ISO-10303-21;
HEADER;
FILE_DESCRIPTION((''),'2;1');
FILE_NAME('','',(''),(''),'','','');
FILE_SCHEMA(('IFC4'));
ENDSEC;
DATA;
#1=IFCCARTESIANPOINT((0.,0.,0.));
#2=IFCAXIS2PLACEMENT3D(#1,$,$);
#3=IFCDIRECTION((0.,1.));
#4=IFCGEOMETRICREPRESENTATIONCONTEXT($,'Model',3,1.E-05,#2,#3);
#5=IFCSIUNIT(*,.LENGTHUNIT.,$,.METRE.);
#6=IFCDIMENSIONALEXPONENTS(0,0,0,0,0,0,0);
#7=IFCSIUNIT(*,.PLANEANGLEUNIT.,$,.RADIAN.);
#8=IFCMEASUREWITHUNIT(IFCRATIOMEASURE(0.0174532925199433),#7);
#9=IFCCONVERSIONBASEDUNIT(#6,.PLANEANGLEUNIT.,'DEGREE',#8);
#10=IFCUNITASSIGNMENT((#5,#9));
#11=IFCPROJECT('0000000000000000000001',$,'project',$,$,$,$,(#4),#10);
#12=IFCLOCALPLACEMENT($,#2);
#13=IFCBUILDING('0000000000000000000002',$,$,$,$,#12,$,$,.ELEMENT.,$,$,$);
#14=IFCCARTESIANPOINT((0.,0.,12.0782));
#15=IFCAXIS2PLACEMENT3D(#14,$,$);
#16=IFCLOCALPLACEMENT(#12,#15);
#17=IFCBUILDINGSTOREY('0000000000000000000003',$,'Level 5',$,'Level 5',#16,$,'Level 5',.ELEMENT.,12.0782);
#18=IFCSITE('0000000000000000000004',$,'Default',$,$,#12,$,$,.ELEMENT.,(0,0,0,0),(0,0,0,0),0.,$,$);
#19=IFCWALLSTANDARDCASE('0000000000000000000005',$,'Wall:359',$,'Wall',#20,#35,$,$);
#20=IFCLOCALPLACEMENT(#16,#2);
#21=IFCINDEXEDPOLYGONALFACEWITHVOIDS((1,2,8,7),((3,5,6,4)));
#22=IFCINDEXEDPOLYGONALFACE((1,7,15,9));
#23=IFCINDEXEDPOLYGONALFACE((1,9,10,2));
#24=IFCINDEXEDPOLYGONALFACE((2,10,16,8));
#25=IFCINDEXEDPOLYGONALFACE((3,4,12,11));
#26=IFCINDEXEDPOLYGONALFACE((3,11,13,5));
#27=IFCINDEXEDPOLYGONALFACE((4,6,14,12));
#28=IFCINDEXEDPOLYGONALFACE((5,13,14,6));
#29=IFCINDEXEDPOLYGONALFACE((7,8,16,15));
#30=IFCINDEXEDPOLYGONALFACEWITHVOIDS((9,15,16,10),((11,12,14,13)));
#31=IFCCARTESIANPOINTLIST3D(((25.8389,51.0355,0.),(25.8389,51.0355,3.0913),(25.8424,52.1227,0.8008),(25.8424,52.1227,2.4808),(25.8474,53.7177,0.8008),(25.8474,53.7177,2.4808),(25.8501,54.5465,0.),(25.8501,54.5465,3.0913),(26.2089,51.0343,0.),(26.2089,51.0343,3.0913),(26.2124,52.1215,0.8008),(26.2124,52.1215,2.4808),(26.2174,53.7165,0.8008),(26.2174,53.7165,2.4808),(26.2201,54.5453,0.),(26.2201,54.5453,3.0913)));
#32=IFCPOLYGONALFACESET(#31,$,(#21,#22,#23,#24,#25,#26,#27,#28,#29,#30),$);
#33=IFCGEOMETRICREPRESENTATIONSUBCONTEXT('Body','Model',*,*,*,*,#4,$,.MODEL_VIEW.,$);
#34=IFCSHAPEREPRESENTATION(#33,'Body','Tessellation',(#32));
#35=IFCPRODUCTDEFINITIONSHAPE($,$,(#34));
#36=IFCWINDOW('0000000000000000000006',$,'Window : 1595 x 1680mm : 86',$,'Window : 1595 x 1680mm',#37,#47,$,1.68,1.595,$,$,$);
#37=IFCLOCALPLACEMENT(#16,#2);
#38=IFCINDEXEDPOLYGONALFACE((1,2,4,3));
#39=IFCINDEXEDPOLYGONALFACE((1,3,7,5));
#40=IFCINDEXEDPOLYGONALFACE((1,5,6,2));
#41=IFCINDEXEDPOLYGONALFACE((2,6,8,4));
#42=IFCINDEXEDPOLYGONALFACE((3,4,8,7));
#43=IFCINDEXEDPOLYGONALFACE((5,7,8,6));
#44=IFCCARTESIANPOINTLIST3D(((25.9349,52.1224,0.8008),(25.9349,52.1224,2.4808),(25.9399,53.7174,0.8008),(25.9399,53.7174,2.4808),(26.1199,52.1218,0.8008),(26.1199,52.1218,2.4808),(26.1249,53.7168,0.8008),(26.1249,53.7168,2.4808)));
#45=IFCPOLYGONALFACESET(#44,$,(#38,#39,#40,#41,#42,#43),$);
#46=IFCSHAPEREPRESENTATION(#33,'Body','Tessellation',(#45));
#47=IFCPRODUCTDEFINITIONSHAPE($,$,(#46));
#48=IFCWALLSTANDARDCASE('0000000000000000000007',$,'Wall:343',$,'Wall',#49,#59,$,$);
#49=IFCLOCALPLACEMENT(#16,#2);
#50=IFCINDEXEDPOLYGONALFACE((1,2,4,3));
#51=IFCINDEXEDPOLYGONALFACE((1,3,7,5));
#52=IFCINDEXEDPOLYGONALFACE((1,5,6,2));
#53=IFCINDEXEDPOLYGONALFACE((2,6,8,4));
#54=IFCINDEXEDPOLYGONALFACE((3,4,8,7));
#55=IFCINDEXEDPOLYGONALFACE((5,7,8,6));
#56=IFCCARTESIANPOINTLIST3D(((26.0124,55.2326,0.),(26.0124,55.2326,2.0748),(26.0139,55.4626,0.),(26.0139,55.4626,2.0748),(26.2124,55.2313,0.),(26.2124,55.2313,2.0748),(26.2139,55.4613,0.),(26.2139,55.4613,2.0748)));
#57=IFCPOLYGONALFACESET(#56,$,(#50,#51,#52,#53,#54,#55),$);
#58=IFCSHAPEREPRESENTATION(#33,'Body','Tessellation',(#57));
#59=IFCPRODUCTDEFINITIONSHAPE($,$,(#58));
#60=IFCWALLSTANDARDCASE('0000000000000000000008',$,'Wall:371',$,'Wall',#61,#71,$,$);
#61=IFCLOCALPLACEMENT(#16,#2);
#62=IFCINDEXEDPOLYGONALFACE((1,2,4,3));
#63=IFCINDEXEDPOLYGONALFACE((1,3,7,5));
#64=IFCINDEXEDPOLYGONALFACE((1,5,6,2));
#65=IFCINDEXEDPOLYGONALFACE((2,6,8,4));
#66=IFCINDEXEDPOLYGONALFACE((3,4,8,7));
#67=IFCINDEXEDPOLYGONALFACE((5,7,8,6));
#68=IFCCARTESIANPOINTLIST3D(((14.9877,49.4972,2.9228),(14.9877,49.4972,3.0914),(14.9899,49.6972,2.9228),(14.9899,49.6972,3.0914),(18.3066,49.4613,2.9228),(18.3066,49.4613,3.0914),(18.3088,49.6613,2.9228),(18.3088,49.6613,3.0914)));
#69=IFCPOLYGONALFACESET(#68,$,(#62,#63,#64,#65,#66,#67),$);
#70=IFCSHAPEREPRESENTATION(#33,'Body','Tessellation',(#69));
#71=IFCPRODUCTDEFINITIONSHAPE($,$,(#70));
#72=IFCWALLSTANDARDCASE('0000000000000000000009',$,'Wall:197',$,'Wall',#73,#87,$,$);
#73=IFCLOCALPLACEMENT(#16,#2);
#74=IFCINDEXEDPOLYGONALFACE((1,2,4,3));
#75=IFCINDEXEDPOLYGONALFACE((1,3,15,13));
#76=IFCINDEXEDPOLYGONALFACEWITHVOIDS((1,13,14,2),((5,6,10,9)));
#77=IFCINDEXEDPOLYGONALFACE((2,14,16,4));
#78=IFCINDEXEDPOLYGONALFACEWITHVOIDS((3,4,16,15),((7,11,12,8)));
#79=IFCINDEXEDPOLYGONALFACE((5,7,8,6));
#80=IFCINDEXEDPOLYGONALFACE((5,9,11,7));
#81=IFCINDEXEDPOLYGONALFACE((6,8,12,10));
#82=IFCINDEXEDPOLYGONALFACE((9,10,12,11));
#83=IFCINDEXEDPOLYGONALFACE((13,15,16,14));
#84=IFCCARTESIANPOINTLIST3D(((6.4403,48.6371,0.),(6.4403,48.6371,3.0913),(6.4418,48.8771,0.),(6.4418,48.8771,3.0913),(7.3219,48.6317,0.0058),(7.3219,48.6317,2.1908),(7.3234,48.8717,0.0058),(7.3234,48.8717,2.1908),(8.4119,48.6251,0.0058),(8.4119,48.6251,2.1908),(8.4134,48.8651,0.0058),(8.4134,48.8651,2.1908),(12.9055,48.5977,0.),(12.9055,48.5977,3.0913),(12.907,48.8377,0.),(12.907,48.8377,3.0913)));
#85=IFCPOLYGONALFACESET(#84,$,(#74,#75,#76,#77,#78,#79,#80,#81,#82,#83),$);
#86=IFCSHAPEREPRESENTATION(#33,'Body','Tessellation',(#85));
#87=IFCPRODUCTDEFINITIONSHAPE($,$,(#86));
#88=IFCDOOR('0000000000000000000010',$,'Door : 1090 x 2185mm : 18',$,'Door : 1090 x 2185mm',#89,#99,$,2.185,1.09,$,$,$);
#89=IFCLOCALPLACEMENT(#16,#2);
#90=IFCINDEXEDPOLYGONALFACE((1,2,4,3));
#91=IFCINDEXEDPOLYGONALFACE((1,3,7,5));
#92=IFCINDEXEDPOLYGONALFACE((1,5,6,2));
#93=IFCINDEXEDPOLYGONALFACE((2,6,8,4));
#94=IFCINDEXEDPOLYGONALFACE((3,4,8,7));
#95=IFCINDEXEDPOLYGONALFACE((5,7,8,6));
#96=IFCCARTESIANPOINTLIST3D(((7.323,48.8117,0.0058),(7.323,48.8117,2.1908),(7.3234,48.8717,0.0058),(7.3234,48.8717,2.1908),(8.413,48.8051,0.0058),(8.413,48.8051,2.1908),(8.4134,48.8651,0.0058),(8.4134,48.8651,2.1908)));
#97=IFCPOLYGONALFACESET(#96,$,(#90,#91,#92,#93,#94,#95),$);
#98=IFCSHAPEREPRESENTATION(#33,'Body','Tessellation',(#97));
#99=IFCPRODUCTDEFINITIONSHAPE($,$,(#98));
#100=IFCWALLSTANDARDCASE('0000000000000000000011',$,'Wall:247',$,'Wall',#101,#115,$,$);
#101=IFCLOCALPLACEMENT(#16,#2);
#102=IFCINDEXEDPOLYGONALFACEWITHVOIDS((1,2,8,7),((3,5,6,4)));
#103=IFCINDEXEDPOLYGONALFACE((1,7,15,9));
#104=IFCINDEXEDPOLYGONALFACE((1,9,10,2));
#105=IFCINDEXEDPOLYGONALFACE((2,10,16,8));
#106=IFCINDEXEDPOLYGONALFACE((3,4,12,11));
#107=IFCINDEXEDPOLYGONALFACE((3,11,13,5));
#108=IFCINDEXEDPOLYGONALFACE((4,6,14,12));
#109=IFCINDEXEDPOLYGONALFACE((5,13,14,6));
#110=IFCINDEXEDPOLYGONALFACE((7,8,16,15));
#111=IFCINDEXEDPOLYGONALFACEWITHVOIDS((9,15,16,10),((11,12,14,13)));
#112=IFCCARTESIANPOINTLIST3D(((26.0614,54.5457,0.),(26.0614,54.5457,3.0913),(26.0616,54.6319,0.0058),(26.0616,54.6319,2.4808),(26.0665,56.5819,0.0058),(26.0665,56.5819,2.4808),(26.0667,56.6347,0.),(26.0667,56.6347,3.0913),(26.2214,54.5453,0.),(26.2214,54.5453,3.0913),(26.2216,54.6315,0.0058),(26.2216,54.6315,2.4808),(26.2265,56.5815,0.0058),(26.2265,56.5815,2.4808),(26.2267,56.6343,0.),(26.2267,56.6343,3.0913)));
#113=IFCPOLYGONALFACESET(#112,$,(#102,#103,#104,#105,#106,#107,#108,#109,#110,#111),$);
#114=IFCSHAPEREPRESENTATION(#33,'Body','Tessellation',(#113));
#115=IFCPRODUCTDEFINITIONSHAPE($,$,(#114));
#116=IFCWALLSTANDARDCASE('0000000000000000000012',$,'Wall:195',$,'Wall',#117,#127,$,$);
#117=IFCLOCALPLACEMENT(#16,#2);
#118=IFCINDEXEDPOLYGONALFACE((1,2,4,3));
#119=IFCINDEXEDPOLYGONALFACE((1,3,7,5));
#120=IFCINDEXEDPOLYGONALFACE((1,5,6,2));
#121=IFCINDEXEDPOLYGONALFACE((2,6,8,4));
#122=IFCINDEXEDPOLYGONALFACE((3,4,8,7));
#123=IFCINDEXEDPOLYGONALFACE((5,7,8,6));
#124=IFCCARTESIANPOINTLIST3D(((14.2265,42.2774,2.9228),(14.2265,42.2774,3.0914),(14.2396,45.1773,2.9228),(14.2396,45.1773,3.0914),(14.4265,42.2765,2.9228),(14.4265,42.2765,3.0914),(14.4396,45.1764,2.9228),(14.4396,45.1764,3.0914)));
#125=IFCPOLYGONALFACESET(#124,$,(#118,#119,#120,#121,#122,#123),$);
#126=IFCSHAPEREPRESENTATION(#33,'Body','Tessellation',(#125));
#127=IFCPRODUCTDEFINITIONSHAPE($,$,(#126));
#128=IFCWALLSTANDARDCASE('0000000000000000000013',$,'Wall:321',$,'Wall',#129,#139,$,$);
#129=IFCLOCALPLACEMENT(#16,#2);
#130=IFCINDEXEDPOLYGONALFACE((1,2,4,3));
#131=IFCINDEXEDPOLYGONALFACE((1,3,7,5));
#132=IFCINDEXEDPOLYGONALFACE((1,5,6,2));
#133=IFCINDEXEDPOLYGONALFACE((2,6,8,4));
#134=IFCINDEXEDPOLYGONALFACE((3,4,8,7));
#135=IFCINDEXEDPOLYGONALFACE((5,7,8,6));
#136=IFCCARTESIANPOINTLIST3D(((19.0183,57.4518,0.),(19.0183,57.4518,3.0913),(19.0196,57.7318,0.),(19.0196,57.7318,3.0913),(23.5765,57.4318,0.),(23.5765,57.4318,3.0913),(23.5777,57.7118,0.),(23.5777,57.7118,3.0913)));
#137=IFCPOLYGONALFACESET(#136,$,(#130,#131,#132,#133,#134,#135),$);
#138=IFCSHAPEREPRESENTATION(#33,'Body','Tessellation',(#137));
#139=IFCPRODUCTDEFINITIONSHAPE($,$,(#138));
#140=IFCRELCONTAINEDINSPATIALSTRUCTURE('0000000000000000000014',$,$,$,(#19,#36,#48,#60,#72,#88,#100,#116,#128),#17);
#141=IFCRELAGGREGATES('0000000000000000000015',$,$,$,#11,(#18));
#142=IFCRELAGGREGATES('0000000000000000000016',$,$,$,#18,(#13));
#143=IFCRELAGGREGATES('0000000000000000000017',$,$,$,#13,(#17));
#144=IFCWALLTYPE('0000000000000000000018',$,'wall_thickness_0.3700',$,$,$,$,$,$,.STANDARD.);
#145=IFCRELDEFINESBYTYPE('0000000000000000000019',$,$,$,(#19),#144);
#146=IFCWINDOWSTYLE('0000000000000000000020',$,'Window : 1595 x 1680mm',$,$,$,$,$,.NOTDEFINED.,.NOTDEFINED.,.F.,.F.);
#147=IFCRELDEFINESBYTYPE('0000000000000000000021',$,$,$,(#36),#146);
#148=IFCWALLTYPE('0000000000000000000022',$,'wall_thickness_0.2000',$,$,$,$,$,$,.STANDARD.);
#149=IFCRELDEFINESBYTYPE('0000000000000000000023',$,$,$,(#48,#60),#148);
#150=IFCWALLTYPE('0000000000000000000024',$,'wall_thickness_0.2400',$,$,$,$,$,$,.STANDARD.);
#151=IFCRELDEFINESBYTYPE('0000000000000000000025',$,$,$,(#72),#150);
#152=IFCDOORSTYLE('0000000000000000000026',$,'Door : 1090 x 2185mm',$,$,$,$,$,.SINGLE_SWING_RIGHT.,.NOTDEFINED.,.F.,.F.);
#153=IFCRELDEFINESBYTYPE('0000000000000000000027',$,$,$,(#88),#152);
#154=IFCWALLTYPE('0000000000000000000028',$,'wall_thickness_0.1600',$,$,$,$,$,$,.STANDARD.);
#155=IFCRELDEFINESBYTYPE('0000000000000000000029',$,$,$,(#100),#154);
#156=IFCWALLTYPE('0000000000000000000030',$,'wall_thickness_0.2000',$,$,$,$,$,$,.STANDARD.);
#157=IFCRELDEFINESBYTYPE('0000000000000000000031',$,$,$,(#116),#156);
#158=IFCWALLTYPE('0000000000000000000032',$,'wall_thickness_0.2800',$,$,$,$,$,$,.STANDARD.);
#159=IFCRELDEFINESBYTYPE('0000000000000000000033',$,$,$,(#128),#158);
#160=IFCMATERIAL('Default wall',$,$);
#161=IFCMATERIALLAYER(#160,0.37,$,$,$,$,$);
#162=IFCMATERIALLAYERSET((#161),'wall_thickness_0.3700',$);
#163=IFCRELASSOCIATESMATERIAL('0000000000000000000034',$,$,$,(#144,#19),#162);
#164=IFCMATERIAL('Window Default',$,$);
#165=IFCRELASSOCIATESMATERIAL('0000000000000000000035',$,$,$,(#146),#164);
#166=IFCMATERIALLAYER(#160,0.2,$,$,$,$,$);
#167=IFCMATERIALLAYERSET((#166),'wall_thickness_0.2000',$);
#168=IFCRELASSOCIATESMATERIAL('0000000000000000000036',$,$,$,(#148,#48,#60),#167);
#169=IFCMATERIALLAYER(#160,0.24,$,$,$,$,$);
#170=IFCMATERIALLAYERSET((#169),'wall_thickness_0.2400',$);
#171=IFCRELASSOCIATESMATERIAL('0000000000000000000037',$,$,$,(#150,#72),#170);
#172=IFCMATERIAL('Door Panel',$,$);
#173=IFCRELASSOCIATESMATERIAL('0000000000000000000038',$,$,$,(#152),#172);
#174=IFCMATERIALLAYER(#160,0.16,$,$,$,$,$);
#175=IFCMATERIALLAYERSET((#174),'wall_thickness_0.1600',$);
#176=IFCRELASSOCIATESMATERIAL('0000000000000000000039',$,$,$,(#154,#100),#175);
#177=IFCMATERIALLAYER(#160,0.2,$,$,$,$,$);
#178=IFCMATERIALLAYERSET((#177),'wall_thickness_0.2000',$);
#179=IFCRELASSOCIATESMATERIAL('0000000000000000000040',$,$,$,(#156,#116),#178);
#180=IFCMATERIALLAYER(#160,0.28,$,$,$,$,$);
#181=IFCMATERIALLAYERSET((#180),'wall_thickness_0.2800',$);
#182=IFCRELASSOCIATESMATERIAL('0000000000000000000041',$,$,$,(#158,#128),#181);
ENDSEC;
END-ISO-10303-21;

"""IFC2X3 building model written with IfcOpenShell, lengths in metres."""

from ifc_helpers import new_model, entity, si_unit, converted_unit, direction, frame, frame_2d, origin, origin_2d_with_axis, place, context, subcontext, project, spatial, polyline, rectangle, outline, extrude, clip, halfspace, source, transform, mapped, material, layer, layer_set, layer_usage, type_object, type_shapes, element, fill, save


model = new_model("IFC2X3")

# Units and contexts
model_context = context("Model", 3, precision=1e-05, world=origin(), true_north=direction((0.0, 1.0)))
body_context = subcontext(model_context, "Body", "Model", "MODEL_VIEW")
ifc_project = project(units=[si_unit("LENGTHUNIT", "METRE"), converted_unit("PLANEANGLEUNIT", "DEGREE", entity("IfcRatioMeasure", 0.0174532925199433), si_unit("PLANEANGLEUNIT", "RADIAN"), dimensions=[0, 0, 0, 0, 0, 0, 0])], contexts=[model_context])

# Site, building, storey
placement_1 = place(None, origin())
site = spatial("IfcSite", under=ifc_project, at=placement_1, Name="Default", CompositionType="ELEMENT", RefLatitude=(0, 0, 0, 0), RefLongitude=(0, 0, 0, 0), RefElevation=0.0)
building = spatial("IfcBuilding", under=site, at=placement_1, CompositionType="ELEMENT")
storey_placement = place(placement_1, frame((0.0, 0.0, 12.0782)))
storey = spatial("IfcBuildingStorey", under=building, at=storey_placement, Name="Level 5", ObjectType="Level 5", LongName="Level 5", CompositionType="ELEMENT", Elevation=12.0782)

# Shared definitions
ifc_material_1 = material(Name="Default wall")

# Shared definitions
ifc_material_2 = material(Name="Window Default")

# Shared definitions
ifc_material_3 = material(Name="Door Panel")

# Shared definitions
ifc_layer_1 = layer(ifc_material_1, 0.37)
ifc_layer_set_1 = layer_set([ifc_layer_1], Name="wall_thickness_0.3700")
ifc_layer_usage_1 = layer_usage(ifc_layer_set_1, "AXIS2", "POSITIVE", -0.185)
wall_type_1 = type_object("IfcWallType", Name="wall_thickness_0.3700", PredefinedType="STANDARD", material=ifc_layer_set_1)

# Wall, opening, window
wall_1_placement = place(storey_placement, frame((26.0351, 54.5459, 0.0), z_axis=(0.0, 0.0, 1.0), x_axis=(-0.00319, -0.999995, 0.0)))
wall_1 = element("IfcWallStandardCase", 1, at=wall_1_placement, inside=storey, type_object=wall_type_1, material=ifc_layer_usage_1, Name="Wall:359", ObjectType="Wall", context=body_context, shape_type="SweptSolid", body=[
    extrude(outline(polyline([(3.5111, -0.185), (3.5111, 0.185), (0.0, 0.185), (0.0, -0.185), (3.5111, -0.185)])), origin(), (0.0, 0.0, 1.0), 3.0913),
])
opening_1_placement = place(wall_1_placement, frame((0.8288, -0.185, 0.8008)))
opening_1 = element("IfcOpeningElement", 2, at=opening_1_placement, cuts=wall_1, ObjectType="Opening", context=body_context, shape_type="SweptSolid", body=[
    extrude(rectangle(XDim=1.595, YDim=1.68, at=frame_2d((0.84, 0.7975), x_axis=(0.0, 1.0))), frame((0.0, 0.0, 0.0), z_axis=(0.0, 1.0, 0.0), x_axis=(0.0, 0.0, 1.0)), (0.0, 0.0, 1.0), 0.37),
])
window_style_1 = type_object("IfcWindowStyle", Name="Window : 1595 x 1680mm", ConstructionType="NOTDEFINED", OperationType="NOTDEFINED", ParameterTakesPrecedence=False, Sizeable=False, material=ifc_material_2)
shared_shape_1 = source(origin(), body_context, "Body", "SweptSolid", [
    extrude(rectangle(XDim=0.185, YDim=1.595, at=origin_2d_with_axis()), frame((0.7975, 0.185, 0.0), z_axis=(0.0, 0.0, 1.0), x_axis=(0.0, 1.0, 0.0)), (0.0, 0.0, 1.0), 1.68),
])
type_shapes(window_style_1, [shared_shape_1])
window_1_placement = place(opening_1_placement, origin())
window_1 = element("IfcWindow", 3, at=window_1_placement, inside=storey, type_object=window_style_1, Name="Window : 1595 x 1680mm : 86", ObjectType="Window : 1595 x 1680mm", OverallHeight=1.68, OverallWidth=1.595, context=body_context, shape_type="MappedRepresentation", body=[
    mapped(shared_shape_1, transform((0.0, 0.0, 0.0), scale=1.0)),
])
fill(opening_1, window_1)

# Walls
ifc_layer_2 = layer(ifc_material_1, 0.2)
ifc_layer_set_2 = layer_set([ifc_layer_2], Name="wall_thickness_0.2000")
ifc_layer_usage_2 = layer_usage(ifc_layer_set_2, "AXIS2", "POSITIVE", -0.1)
wall_type_2 = type_object("IfcWallType", Name="wall_thickness_0.2000", PredefinedType="STANDARD", material=ifc_layer_set_2)
wall_2_placement = place(storey_placement, frame((26.1139, 55.4619, 0.0), z_axis=(0.0, 0.0, 1.0), x_axis=(-0.006286, -0.99998, 0.0)))
element("IfcWallStandardCase", 4, at=wall_2_placement, inside=storey, type_object=wall_type_2, material=ifc_layer_usage_2, Name="Wall:343", ObjectType="Wall", context=body_context, shape_type="SweptSolid", body=[
    extrude(outline(polyline([(0.23, -0.1), (0.23, 0.1), (0.0, 0.1), (0.0, -0.1), (0.23, -0.1)])), origin(), (0.0, 0.0, 1.0), 2.0748),
])
placement_2 = place(placement_1, frame((0.0, 0.0, 15.001)))
wall_3_placement = place(placement_2, frame((14.9888, 49.5972, 0.0), z_axis=(0.0, 0.0, 1.0), x_axis=(0.999942, -0.010814, 0.0)))
element("IfcWallStandardCase", 5, at=wall_3_placement, inside=storey, type_object=wall_type_2, material=ifc_layer_usage_2, Name="Wall:371", ObjectType="Wall", context=body_context, shape_type="SweptSolid", body=[
    extrude(outline(polyline([(3.3191, -0.1), (3.3191, 0.1), (0.0, 0.1), (0.0, -0.1), (3.3191, -0.1)])), origin(), (0.0, 0.0, 1.0), 0.1686),
])

# Wall, opening, door
ifc_layer_3 = layer(ifc_material_1, 0.24)
ifc_layer_set_3 = layer_set([ifc_layer_3], Name="wall_thickness_0.2400")
ifc_layer_usage_3 = layer_usage(ifc_layer_set_3, "AXIS2", "POSITIVE", -0.12)
wall_type_3 = type_object("IfcWallType", Name="wall_thickness_0.2400", PredefinedType="STANDARD", material=ifc_layer_set_3)
wall_4_placement = place(storey_placement, frame((6.4411, 48.7571, 0.0), z_axis=(0.0, 0.0, 1.0), x_axis=(0.999981, -0.006101, 0.0)))
wall_4 = element("IfcWallStandardCase", 6, at=wall_4_placement, inside=storey, type_object=wall_type_3, material=ifc_layer_usage_3, Name="Wall:197", ObjectType="Wall", context=body_context, shape_type="Clipping", body=[
    clip(extrude(outline(polyline([(6.4653, -0.12), (6.4653, 0.12), (0.0, 0.12), (0.0, -0.12), (6.4653, -0.12)])), origin(), (0.0, 0.0, 1.0), 3.0913), halfspace(frame((7.4672, 28.5225, 5.8218), z_axis=(0.390505, 0.000479, 0.920601), x_axis=(-0.920599, -0.001625, 0.390505)), False)),
])
opening_2_placement = place(wall_4_placement, frame((0.8816, -0.12, 0.0058)))
opening_2 = element("IfcOpeningElement", 7, at=opening_2_placement, cuts=wall_4, ObjectType="Opening", context=body_context, shape_type="SweptSolid", body=[
    extrude(rectangle(XDim=1.09, YDim=2.185, at=frame_2d((1.0925, 0.545), x_axis=(0.0, 1.0))), frame((0.0, 0.0, 0.0), z_axis=(0.0, 1.0, 0.0), x_axis=(0.0, 0.0, 1.0)), (0.0, 0.0, 1.0), 0.24),
])
door_style_1 = type_object("IfcDoorStyle", Name="Door : 1090 x 2185mm", ConstructionType="NOTDEFINED", OperationType="SINGLE_SWING_RIGHT", ParameterTakesPrecedence=False, Sizeable=False, material=ifc_material_3)
shared_shape_2 = source(origin(), body_context, "Body", "SweptSolid", [
    extrude(rectangle(XDim=0.06, YDim=1.09, at=origin_2d_with_axis()), frame((0.545, 0.21, 0.0), z_axis=(0.0, 0.0, 1.0), x_axis=(0.0, 1.0, 0.0)), (0.0, 0.0, 1.0), 2.185),
])
type_shapes(door_style_1, [shared_shape_2])
door_1_placement = place(opening_2_placement, origin())
door_1 = element("IfcDoor", 8, at=door_1_placement, inside=storey, type_object=door_style_1, Name="Door : 1090 x 2185mm : 18", ObjectType="Door : 1090 x 2185mm", OverallHeight=2.185, OverallWidth=1.09, context=body_context, shape_type="MappedRepresentation", body=[
    mapped(shared_shape_2, transform((0.0, 0.0, 0.0), scale=1.0)),
])
fill(opening_2, door_1)

# Wall, opening
ifc_layer_4 = layer(ifc_material_1, 0.16)
ifc_layer_set_4 = layer_set([ifc_layer_4], Name="wall_thickness_0.1600")
ifc_layer_usage_4 = layer_usage(ifc_layer_set_4, "AXIS2", "POSITIVE", -0.08)
wall_type_4 = type_object("IfcWallType", Name="wall_thickness_0.1600", PredefinedType="STANDARD", material=ifc_layer_set_4)
wall_5_placement = place(storey_placement, frame((26.1467, 56.6345, 0.0), z_axis=(0.0, 0.0, 1.0), x_axis=(-0.002537, -0.999997, 0.0)))
wall_5 = element("IfcWallStandardCase", 9, at=wall_5_placement, inside=storey, type_object=wall_type_4, material=ifc_layer_usage_4, Name="Wall:247", ObjectType="Wall", context=body_context, shape_type="SweptSolid", body=[
    extrude(outline(polyline([(2.0889, -0.08), (2.0889, 0.08), (0.0, 0.08), (0.0, -0.08), (2.0889, -0.08)])), origin(), (0.0, 0.0, 1.0), 3.0913),
])
opening_3_placement = place(wall_5_placement, frame((0.0527, -0.08, 0.0058)))
element("IfcOpeningElement", 10, at=opening_3_placement, cuts=wall_5, ObjectType="Opening", context=body_context, shape_type="SweptSolid", body=[
    extrude(rectangle(XDim=1.95, YDim=2.475, at=frame_2d((1.2375, 0.975), x_axis=(0.0, 1.0))), frame((0.0, 0.0, 0.0), z_axis=(0.0, 1.0, 0.0), x_axis=(0.0, 0.0, 1.0)), (0.0, 0.0, 1.0), 0.16),
])

# Walls
ifc_layer_5 = layer(ifc_material_1, 0.2)
ifc_layer_set_5 = layer_set([ifc_layer_5], Name="wall_thickness_0.2000")
ifc_layer_usage_5 = layer_usage(ifc_layer_set_5, "AXIS2", "POSITIVE", -0.1)
wall_type_5 = type_object("IfcWallType", Name="wall_thickness_0.2000", PredefinedType="STANDARD", material=ifc_layer_set_5)
placement_3 = place(placement_1, frame((0.0, 0.0, 15.001)))
wall_6_placement = place(placement_3, frame((14.3396, 45.1768, 0.0), z_axis=(0.0, 0.0, 1.0), x_axis=(-0.004506, -0.99999, 0.0)))
element("IfcWallStandardCase", 11, at=wall_6_placement, inside=storey, type_object=wall_type_5, material=ifc_layer_usage_5, Name="Wall:195", ObjectType="Wall", context=body_context, shape_type="SweptSolid", body=[
    extrude(outline(polyline([(2.8999, -0.1), (2.8999, 0.1), (0.0, 0.1), (0.0, -0.1), (2.8999, -0.1)])), origin(), (0.0, 0.0, 1.0), 0.1686),
])
ifc_layer_6 = layer(ifc_material_1, 0.28)
ifc_layer_set_6 = layer_set([ifc_layer_6], Name="wall_thickness_0.2800")
ifc_layer_usage_6 = layer_usage(ifc_layer_set_6, "AXIS2", "POSITIVE", -0.14)
wall_type_6 = type_object("IfcWallType", Name="wall_thickness_0.2800", PredefinedType="STANDARD", material=ifc_layer_set_6)
wall_7_placement = place(storey_placement, frame((19.0189, 57.5918, 0.0), z_axis=(0.0, 0.0, 1.0), x_axis=(0.99999, -0.004399, 0.0)))
element("IfcWallStandardCase", 12, at=wall_7_placement, inside=storey, type_object=wall_type_6, material=ifc_layer_usage_6, Name="Wall:321", ObjectType="Wall", context=body_context, shape_type="Clipping", body=[
    clip(extrude(outline(polyline([(4.5582, -0.14), (4.5582, 0.14), (0.0, 0.14), (0.0, -0.14), (4.5582, -0.14)])), origin(), (0.0, 0.0, 1.0), 3.0913), halfspace(frame((5.6081, -0.0646, 9.0135), z_axis=(0.00076, 0.389455, 0.921045), x_axis=(-0.999993, 0.003747, -0.000759)), False)),
])

save(model, "model.ifc")
